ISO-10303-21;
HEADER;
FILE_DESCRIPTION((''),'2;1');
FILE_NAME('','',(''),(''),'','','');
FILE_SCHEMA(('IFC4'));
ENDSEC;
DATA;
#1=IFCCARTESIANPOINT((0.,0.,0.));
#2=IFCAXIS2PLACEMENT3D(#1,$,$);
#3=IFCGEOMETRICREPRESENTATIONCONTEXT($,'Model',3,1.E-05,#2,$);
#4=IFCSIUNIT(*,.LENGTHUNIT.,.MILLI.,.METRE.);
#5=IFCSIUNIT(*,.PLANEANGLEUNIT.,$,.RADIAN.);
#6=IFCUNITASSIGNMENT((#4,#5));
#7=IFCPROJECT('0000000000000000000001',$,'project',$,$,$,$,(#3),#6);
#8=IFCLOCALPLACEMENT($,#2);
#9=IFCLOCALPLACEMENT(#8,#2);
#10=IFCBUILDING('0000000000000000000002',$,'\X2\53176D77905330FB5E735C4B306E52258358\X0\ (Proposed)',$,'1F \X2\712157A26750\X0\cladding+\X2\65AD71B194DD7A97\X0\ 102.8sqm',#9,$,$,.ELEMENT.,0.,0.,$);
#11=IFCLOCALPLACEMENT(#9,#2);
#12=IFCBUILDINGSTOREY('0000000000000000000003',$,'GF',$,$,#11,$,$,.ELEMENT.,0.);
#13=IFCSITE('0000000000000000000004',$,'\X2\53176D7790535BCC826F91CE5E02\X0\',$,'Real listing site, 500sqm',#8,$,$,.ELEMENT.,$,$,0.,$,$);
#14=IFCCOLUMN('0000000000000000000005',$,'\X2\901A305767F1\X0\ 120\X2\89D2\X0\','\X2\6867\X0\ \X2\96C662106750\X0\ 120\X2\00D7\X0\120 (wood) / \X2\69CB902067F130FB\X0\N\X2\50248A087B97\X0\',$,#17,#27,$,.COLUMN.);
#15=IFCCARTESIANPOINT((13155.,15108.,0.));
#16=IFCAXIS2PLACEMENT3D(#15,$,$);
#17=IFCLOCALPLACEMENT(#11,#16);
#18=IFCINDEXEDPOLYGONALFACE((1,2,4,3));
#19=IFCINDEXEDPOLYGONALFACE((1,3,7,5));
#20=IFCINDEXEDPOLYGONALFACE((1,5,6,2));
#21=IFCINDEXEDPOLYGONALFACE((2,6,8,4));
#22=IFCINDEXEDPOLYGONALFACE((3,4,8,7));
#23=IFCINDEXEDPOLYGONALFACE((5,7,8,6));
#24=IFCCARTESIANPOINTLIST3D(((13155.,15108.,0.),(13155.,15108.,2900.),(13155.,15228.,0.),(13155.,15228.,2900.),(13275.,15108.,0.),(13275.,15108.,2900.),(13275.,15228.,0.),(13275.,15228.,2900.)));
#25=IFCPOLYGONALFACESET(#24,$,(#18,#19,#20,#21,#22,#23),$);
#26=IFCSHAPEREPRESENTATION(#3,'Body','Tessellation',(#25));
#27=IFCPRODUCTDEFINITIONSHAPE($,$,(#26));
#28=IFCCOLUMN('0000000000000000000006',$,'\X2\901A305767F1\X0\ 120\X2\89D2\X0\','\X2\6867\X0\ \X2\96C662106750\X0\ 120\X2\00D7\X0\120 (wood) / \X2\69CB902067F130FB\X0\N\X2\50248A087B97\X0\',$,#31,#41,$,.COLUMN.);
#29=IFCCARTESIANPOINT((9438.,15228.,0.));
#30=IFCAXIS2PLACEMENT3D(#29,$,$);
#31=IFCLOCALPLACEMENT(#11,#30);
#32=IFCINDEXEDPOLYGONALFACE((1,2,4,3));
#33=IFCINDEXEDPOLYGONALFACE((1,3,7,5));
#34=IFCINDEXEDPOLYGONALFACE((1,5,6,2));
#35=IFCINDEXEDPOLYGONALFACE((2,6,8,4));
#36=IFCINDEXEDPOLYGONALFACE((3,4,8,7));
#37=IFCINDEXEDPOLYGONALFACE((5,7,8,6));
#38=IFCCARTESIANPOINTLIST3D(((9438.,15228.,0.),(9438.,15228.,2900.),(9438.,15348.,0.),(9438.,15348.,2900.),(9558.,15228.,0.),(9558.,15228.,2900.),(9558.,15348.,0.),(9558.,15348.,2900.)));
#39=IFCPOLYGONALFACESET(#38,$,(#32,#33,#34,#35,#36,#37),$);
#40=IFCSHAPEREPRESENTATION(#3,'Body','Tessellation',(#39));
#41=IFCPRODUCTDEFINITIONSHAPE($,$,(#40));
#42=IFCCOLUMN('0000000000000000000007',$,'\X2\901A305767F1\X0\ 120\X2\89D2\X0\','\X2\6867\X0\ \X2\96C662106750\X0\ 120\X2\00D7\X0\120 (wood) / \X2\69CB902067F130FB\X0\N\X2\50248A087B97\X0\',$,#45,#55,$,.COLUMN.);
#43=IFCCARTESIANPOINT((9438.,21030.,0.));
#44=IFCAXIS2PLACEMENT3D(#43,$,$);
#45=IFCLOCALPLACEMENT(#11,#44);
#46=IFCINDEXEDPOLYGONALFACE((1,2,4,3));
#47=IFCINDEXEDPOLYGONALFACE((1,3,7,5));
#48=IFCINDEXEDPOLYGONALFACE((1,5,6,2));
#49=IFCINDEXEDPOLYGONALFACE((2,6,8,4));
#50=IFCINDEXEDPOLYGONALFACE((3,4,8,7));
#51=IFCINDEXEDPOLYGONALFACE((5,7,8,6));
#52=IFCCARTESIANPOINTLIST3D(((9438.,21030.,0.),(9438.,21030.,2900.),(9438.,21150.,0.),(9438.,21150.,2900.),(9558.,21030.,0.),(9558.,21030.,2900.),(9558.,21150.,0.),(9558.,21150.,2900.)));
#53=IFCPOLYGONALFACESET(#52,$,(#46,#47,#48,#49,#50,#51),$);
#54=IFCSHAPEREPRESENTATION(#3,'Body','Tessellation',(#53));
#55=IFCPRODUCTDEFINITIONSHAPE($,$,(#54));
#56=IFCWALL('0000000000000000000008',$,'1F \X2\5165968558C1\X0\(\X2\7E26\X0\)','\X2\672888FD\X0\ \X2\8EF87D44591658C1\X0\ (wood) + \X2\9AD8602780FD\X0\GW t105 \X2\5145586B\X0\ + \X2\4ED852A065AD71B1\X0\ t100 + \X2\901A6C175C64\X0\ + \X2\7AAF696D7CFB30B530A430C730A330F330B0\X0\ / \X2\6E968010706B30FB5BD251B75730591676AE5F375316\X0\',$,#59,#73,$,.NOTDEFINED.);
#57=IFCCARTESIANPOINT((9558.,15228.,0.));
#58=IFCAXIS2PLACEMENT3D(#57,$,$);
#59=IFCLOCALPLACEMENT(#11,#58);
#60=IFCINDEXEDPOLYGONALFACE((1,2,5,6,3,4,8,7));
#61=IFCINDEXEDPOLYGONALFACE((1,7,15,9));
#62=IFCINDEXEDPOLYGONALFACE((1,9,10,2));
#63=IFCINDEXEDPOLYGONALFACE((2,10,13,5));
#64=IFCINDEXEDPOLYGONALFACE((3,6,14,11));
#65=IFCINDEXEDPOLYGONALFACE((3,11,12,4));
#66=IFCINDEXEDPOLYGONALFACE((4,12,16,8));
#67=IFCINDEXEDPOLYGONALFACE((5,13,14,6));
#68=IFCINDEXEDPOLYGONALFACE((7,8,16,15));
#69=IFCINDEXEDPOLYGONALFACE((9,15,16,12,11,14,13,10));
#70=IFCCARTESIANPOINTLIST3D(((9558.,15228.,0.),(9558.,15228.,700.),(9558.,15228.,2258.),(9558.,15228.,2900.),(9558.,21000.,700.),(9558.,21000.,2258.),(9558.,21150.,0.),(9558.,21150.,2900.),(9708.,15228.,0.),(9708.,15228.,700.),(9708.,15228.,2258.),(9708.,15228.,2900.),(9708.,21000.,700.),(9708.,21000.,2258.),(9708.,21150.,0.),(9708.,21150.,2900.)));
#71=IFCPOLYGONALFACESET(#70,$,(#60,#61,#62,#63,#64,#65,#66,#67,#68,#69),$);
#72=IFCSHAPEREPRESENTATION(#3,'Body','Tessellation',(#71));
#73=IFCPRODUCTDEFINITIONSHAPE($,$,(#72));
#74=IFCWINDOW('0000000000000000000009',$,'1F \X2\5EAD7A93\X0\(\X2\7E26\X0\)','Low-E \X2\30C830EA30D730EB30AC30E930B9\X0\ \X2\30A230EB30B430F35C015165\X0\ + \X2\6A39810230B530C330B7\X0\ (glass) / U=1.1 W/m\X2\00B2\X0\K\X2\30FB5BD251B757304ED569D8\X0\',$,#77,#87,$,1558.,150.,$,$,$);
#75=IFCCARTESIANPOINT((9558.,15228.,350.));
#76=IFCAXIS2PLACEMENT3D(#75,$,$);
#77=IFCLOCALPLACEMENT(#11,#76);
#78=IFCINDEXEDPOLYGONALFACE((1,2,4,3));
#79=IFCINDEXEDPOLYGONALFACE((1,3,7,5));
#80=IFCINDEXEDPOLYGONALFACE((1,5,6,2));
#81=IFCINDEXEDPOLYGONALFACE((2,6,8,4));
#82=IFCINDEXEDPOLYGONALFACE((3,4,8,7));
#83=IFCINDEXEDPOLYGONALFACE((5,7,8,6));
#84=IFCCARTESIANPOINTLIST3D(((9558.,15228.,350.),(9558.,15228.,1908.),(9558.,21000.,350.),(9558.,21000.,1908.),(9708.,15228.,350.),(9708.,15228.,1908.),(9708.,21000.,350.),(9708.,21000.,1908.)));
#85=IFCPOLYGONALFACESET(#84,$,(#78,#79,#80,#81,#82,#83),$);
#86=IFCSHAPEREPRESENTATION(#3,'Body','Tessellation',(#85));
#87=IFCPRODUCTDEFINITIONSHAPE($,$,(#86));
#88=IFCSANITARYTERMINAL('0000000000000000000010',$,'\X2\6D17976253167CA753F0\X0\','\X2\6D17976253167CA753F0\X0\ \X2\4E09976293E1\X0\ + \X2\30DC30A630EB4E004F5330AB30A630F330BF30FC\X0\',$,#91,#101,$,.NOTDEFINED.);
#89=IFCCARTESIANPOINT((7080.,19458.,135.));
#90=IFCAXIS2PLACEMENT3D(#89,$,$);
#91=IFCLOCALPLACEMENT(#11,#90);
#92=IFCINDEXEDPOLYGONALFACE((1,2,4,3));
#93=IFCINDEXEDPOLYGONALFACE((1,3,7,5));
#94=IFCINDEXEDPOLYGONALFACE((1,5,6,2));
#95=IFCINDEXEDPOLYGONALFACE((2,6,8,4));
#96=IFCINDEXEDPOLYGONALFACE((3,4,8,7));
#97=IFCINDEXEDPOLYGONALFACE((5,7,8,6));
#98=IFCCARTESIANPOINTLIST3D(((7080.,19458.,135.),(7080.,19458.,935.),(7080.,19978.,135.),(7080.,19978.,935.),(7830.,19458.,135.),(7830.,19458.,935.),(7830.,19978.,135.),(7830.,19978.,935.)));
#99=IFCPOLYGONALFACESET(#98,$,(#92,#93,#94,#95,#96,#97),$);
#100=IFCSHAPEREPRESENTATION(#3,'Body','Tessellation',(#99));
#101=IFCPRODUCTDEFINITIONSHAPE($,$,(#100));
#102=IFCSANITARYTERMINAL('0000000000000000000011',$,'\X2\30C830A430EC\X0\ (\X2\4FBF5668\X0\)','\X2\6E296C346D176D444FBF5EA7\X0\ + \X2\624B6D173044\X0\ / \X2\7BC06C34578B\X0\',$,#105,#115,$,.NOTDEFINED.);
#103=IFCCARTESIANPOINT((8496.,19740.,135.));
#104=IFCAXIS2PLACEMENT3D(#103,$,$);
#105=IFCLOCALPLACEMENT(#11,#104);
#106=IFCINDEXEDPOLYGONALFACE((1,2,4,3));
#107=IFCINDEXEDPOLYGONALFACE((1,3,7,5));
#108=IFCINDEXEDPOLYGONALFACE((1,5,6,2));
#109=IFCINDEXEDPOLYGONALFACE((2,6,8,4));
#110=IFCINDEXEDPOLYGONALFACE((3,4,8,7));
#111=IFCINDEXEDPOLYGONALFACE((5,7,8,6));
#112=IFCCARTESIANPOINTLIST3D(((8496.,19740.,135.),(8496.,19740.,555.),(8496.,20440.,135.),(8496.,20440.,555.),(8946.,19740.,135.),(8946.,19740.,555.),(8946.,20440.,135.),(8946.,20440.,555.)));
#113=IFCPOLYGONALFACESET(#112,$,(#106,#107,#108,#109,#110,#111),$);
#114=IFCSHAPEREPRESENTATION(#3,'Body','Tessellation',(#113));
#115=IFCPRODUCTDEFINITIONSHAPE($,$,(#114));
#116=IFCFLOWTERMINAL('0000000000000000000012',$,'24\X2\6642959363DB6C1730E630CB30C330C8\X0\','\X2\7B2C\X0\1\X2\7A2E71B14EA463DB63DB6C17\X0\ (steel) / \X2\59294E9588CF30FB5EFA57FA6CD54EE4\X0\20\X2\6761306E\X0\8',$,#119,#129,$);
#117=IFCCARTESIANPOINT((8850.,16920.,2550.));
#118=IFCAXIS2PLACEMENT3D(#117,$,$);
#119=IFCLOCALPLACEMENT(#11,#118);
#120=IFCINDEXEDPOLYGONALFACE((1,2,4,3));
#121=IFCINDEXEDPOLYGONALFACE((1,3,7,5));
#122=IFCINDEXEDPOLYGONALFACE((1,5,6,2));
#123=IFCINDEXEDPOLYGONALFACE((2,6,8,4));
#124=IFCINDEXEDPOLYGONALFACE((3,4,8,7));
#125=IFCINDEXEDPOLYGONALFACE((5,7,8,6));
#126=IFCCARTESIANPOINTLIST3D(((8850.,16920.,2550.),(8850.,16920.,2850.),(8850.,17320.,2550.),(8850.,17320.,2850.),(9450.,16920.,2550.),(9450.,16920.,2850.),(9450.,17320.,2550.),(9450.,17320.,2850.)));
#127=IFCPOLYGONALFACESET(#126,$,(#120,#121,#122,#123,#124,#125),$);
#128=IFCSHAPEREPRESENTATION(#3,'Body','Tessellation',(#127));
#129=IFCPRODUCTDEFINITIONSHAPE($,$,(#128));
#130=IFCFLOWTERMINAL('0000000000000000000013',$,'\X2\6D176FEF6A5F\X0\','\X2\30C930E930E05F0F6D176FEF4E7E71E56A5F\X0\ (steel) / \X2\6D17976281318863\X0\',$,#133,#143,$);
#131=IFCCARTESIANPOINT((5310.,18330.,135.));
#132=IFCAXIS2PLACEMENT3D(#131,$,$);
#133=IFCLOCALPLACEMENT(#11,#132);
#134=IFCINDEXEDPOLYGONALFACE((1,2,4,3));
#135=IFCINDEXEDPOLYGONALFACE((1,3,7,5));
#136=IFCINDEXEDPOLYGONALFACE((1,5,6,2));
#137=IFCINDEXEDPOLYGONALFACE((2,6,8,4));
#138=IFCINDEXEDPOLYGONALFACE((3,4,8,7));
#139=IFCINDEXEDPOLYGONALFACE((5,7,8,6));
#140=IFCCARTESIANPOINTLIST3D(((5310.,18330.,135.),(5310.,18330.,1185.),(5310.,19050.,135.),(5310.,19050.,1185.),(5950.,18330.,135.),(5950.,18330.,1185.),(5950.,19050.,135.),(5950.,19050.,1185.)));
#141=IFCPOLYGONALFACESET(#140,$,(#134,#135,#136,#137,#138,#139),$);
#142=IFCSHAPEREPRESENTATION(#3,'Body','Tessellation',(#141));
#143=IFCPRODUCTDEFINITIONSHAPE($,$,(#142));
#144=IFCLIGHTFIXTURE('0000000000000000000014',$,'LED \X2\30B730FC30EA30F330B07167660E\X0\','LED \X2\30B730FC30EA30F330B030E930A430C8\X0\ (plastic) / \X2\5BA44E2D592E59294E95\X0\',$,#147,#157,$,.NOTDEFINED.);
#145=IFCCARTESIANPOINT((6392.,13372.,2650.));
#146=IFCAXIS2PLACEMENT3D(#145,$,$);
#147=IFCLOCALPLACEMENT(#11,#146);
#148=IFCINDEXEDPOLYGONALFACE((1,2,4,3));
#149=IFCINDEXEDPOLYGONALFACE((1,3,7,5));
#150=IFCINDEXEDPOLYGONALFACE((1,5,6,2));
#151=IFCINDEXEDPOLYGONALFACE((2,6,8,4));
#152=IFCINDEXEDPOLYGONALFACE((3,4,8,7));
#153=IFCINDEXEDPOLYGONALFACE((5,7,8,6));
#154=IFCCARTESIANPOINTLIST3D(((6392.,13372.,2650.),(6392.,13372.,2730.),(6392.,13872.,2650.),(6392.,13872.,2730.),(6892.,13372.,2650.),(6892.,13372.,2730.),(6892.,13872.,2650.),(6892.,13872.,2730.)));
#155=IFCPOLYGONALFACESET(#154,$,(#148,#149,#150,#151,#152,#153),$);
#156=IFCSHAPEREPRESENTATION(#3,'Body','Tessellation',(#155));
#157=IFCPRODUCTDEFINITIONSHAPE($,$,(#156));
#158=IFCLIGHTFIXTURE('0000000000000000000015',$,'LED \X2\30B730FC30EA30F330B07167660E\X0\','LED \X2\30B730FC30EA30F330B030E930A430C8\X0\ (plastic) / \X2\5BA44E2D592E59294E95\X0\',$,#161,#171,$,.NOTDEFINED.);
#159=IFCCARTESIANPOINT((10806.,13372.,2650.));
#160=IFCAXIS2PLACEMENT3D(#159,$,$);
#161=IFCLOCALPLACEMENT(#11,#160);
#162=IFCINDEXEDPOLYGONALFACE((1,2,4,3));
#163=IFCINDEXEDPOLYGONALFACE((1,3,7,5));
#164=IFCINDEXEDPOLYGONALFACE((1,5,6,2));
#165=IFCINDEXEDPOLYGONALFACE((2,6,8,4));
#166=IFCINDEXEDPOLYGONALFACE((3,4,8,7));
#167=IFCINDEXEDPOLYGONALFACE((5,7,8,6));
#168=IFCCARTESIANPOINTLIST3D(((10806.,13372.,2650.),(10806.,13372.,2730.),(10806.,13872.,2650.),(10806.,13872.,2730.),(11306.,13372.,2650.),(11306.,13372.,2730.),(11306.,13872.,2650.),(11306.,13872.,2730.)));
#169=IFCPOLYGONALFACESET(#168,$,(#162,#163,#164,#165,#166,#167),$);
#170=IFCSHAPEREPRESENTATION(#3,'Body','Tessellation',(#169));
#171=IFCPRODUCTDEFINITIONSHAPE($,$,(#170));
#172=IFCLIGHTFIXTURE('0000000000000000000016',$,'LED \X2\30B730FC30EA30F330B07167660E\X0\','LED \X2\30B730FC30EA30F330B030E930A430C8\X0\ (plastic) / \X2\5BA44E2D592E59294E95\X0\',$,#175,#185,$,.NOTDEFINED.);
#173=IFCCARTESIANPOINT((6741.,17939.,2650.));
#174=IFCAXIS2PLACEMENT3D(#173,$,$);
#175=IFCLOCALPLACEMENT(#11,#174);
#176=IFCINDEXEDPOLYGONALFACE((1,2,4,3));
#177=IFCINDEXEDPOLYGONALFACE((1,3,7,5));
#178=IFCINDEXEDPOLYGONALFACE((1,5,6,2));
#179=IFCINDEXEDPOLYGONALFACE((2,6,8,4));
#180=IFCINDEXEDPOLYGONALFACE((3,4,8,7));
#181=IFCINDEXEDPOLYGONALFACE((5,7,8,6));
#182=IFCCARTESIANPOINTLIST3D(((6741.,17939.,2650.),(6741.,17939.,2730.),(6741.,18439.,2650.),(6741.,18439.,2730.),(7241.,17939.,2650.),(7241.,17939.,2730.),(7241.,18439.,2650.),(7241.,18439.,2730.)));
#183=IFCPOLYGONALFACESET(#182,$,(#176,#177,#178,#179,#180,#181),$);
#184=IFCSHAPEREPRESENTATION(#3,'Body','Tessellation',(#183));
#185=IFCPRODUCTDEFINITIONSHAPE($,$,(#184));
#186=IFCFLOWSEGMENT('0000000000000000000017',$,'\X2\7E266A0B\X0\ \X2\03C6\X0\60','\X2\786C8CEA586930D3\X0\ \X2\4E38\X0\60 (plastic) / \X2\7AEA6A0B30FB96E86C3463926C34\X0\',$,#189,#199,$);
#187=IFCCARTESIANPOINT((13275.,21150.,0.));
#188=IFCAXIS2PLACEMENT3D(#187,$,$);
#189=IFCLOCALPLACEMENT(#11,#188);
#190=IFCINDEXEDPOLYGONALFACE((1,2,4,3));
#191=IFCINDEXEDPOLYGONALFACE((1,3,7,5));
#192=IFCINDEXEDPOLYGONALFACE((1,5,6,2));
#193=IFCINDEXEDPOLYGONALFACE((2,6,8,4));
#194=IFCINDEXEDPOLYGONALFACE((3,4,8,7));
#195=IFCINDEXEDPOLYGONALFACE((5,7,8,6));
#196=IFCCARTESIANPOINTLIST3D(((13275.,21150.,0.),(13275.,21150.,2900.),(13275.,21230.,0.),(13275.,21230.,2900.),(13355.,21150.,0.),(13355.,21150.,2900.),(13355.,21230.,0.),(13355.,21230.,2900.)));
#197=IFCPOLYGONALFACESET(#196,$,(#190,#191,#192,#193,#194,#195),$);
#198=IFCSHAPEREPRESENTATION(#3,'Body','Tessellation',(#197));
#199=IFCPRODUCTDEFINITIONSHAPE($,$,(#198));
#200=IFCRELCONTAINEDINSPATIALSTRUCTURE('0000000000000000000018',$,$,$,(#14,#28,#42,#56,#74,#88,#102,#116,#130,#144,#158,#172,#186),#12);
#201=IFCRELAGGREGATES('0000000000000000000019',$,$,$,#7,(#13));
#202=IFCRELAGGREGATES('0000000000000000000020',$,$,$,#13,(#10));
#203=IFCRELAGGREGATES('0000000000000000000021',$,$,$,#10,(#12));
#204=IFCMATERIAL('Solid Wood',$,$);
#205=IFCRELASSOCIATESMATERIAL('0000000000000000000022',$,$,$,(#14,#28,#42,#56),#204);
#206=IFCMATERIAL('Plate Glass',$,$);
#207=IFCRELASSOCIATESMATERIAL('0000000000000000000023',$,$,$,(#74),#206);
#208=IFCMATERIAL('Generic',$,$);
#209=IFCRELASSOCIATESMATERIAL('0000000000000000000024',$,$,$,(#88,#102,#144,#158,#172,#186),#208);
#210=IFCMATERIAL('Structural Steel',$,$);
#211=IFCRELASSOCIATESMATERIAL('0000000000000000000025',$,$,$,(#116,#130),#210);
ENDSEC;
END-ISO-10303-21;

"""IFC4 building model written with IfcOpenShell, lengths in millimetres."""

from ifc_helpers import new_model, si_unit, frame, frame_2d, origin, place, context, project, spatial, rectangle, extrude, material, element, fill, save


model = new_model("IFC4")

# Units and contexts
model_context = context("Model", 3, precision=1e-05, world=origin())
ifc_project = project(units=[si_unit("LENGTHUNIT", "METRE", prefix="MILLI"), si_unit("PLANEANGLEUNIT", "RADIAN")], contexts=[model_context])

# Site, building, storey
site_placement = place(None, origin())
site = spatial("IfcSite", under=ifc_project, at=site_placement, Name="北海道富良野市", ObjectType="Real listing site, 500sqm", CompositionType="ELEMENT", RefElevation=0.0)
building_placement = place(site_placement, origin())
building = spatial("IfcBuilding", under=site, at=building_placement, Name="北海道・平屋の別荘 (Proposed)", ObjectType="1F 無垢材cladding+断熱铝窗 102.8sqm", CompositionType="ELEMENT", ElevationOfRefHeight=0.0, ElevationOfTerrain=0.0)
storey_placement = place(building_placement, origin())
storey = spatial("IfcBuildingStorey", under=building, at=storey_placement, Name="GF", CompositionType="ELEMENT", Elevation=0.0)

# Columns
ifc_material_1 = material(Name="Solid Wood")
column_1_placement = place(storey_placement, frame((13155.0, 15108.0, 0.0)))
element("IfcColumn", 1, at=column_1_placement, inside=storey, material=ifc_material_1, Name="通し柱 120角", Description="桧 集成材 120×120 (wood) / 構造柱・N値計算", PredefinedType="COLUMN", context=model_context, shape_type="SweptSolid", body=[
    extrude(rectangle(XDim=120.0, YDim=120.0, at=frame_2d((60.0, 60.0))), frame((13155.0, 15108.0, 0.0)), (0.0, 0.0, 1.0), 2900.0),
])
column_2_placement = place(storey_placement, frame((9438.0, 15228.0, 0.0)))
element("IfcColumn", 2, at=column_2_placement, inside=storey, material=ifc_material_1, Name="通し柱 120角", Description="桧 集成材 120×120 (wood) / 構造柱・N値計算", PredefinedType="COLUMN", context=model_context, shape_type="SweptSolid", body=[
    extrude(rectangle(XDim=120.0, YDim=120.0, at=frame_2d((60.0, 60.0))), frame((9438.0, 15228.0, 0.0)), (0.0, 0.0, 1.0), 2900.0),
])
column_3_placement = place(storey_placement, frame((9438.0, 21030.0, 0.0)))
element("IfcColumn", 3, at=column_3_placement, inside=storey, material=ifc_material_1, Name="通し柱 120角", Description="桧 集成材 120×120 (wood) / 構造柱・N値計算", PredefinedType="COLUMN", context=model_context, shape_type="SweptSolid", body=[
    extrude(rectangle(XDim=120.0, YDim=120.0, at=frame_2d((60.0, 60.0))), frame((9438.0, 21030.0, 0.0)), (0.0, 0.0, 1.0), 2900.0),
])

# Wall, opening, window
wall_1_placement = place(storey_placement, frame((9558.0, 15228.0, 0.0)))
wall_1 = element("IfcWall", 4, at=wall_1_placement, inside=storey, material=ifc_material_1, Name="1F 入隅壁(縦)", Description="木製 軸組外壁 (wood) + 高性能GW t105 充填 + 付加断熱 t100 + 通気層 + 窯業系サイディング / 準耐火・寒冷地外皮強化", PredefinedType="NOTDEFINED", context=model_context, shape_type="SweptSolid", body=[
    extrude(rectangle(XDim=150.0, YDim=5922.0, at=frame_2d((75.0, 2961.0))), frame((9558.0, 15228.0, 0.0)), (0.0, 0.0, 1.0), 2900.0),
])
opening_placement = place(storey_placement, frame((9558.0, 15228.0, 350.0)))
opening = element("IfcOpeningElement", 5, at=opening_placement, cuts=wall_1, PredefinedType="NOTDEFINED", context=model_context, shape_type="SweptSolid", body=[
    extrude(rectangle(XDim=150.0, YDim=5772.0, at=frame_2d((75.0, 2886.0))), frame((9558.0, 15228.0, 350.0)), (0.0, 0.0, 1.0), 1558.0),
])
ifc_material_2 = material(Name="Plate Glass")
window_placement = place(storey_placement, frame((9558.0, 15228.0, 350.0)))
window = element("IfcWindow", 6, at=window_placement, inside=storey, material=ifc_material_2, Name="1F 庭窓(縦)", Description="Low-E トリプルガラス アルゴン封入 + 樹脂サッシ (glass) / U=1.1 W/m²K・寒冷地仕様", OverallHeight=1558.0, OverallWidth=150.0, context=model_context, shape_type="SweptSolid", body=[
    extrude(rectangle(XDim=150.0, YDim=5772.0, at=frame_2d((75.0, 2886.0))), frame((9558.0, 15228.0, 350.0)), (0.0, 0.0, 1.0), 1558.0),
])
fill(opening, window)

# Sanitary terminals
ifc_material_3 = material(Name="Generic")
sanitary_terminal_1_placement = place(storey_placement, frame((7080.0, 19458.0, 135.0)))
element("IfcSanitaryTerminal", 7, at=sanitary_terminal_1_placement, inside=storey, material=ifc_material_3, Name="洗面化粧台", Description="洗面化粧台 三面鏡 + ボウル一体カウンター", PredefinedType="NOTDEFINED", context=model_context, shape_type="SweptSolid", body=[
    extrude(rectangle(XDim=750.0, YDim=520.0, at=frame_2d((375.0, 260.0))), frame((7080.0, 19458.0, 135.0)), (0.0, 0.0, 1.0), 800.0),
])
sanitary_terminal_2_placement = place(storey_placement, frame((8496.0, 19740.0, 135.0)))
element("IfcSanitaryTerminal", 8, at=sanitary_terminal_2_placement, inside=storey, material=ifc_material_3, Name="トイレ (便器)", Description="温水洗浄便座 + 手洗い / 節水型", PredefinedType="NOTDEFINED", context=model_context, shape_type="SweptSolid", body=[
    extrude(rectangle(XDim=450.0, YDim=700.0, at=frame_2d((225.0, 350.0))), frame((8496.0, 19740.0, 135.0)), (0.0, 0.0, 1.0), 420.0),
])

# Flow terminals
ifc_material_4 = material(Name="Structural Steel")
flow_terminal_1_placement = place(storey_placement, frame((8850.0, 16920.0, 2550.0)))
element("IfcFlowTerminal", 9, at=flow_terminal_1_placement, inside=storey, material=ifc_material_4, Name="24時間換気ユニット", Description="第1種熱交換換気 (steel) / 天井裏・建基法令20条の8", context=model_context, shape_type="SweptSolid", body=[
    extrude(rectangle(XDim=600.0, YDim=400.0, at=frame_2d((300.0, 200.0))), frame((8850.0, 16920.0, 2550.0)), (0.0, 0.0, 1.0), 300.0),
])
flow_terminal_2_placement = place(storey_placement, frame((5310.0, 18330.0, 135.0)))
element("IfcFlowTerminal", 10, at=flow_terminal_2_placement, inside=storey, material=ifc_material_4, Name="洗濯機", Description="ドラム式洗濯乾燥機 (steel) / 洗面脱衣", context=model_context, shape_type="SweptSolid", body=[
    extrude(rectangle(XDim=640.0, YDim=720.0, at=frame_2d((320.0, 360.0))), frame((5310.0, 18330.0, 135.0)), (0.0, 0.0, 1.0), 1050.0),
])

# Light fixtures
light_fixture_1_placement = place(storey_placement, frame((6392.0, 13372.0, 2650.0)))
element("IfcLightFixture", 11, at=light_fixture_1_placement, inside=storey, material=ifc_material_3, Name="LED シーリング照明", Description="LED シーリングライト (plastic) / 室中央天井", PredefinedType="NOTDEFINED", context=model_context, shape_type="SweptSolid", body=[
    extrude(rectangle(XDim=500.0, YDim=500.0, at=frame_2d((250.0, 250.0))), frame((6392.0, 13372.0, 2650.0)), (0.0, 0.0, 1.0), 80.0),
])
light_fixture_2_placement = place(storey_placement, frame((10806.0, 13372.0, 2650.0)))
element("IfcLightFixture", 12, at=light_fixture_2_placement, inside=storey, material=ifc_material_3, Name="LED シーリング照明", Description="LED シーリングライト (plastic) / 室中央天井", PredefinedType="NOTDEFINED", context=model_context, shape_type="SweptSolid", body=[
    extrude(rectangle(XDim=500.0, YDim=500.0, at=frame_2d((250.0, 250.0))), frame((10806.0, 13372.0, 2650.0)), (0.0, 0.0, 1.0), 80.0),
])
light_fixture_3_placement = place(storey_placement, frame((6741.0, 17939.0, 2650.0)))
element("IfcLightFixture", 13, at=light_fixture_3_placement, inside=storey, material=ifc_material_3, Name="LED シーリング照明", Description="LED シーリングライト (plastic) / 室中央天井", PredefinedType="NOTDEFINED", context=model_context, shape_type="SweptSolid", body=[
    extrude(rectangle(XDim=500.0, YDim=500.0, at=frame_2d((250.0, 250.0))), frame((6741.0, 17939.0, 2650.0)), (0.0, 0.0, 1.0), 80.0),
])

# Flow segment
flow_segment_placement = place(storey_placement, frame((13275.0, 21150.0, 0.0)))
element("IfcFlowSegment", 14, at=flow_segment_placement, inside=storey, material=ifc_material_3, Name="縦樋 φ60", Description="硬質塩ビ 丸60 (plastic) / 竪樋・雨水排水", context=model_context, shape_type="SweptSolid", body=[
    extrude(rectangle(XDim=80.0, YDim=80.0, at=frame_2d((40.0, 40.0))), frame((13275.0, 21150.0, 0.0)), (0.0, 0.0, 1.0), 2900.0),
])

save(model, "model.ifc")
